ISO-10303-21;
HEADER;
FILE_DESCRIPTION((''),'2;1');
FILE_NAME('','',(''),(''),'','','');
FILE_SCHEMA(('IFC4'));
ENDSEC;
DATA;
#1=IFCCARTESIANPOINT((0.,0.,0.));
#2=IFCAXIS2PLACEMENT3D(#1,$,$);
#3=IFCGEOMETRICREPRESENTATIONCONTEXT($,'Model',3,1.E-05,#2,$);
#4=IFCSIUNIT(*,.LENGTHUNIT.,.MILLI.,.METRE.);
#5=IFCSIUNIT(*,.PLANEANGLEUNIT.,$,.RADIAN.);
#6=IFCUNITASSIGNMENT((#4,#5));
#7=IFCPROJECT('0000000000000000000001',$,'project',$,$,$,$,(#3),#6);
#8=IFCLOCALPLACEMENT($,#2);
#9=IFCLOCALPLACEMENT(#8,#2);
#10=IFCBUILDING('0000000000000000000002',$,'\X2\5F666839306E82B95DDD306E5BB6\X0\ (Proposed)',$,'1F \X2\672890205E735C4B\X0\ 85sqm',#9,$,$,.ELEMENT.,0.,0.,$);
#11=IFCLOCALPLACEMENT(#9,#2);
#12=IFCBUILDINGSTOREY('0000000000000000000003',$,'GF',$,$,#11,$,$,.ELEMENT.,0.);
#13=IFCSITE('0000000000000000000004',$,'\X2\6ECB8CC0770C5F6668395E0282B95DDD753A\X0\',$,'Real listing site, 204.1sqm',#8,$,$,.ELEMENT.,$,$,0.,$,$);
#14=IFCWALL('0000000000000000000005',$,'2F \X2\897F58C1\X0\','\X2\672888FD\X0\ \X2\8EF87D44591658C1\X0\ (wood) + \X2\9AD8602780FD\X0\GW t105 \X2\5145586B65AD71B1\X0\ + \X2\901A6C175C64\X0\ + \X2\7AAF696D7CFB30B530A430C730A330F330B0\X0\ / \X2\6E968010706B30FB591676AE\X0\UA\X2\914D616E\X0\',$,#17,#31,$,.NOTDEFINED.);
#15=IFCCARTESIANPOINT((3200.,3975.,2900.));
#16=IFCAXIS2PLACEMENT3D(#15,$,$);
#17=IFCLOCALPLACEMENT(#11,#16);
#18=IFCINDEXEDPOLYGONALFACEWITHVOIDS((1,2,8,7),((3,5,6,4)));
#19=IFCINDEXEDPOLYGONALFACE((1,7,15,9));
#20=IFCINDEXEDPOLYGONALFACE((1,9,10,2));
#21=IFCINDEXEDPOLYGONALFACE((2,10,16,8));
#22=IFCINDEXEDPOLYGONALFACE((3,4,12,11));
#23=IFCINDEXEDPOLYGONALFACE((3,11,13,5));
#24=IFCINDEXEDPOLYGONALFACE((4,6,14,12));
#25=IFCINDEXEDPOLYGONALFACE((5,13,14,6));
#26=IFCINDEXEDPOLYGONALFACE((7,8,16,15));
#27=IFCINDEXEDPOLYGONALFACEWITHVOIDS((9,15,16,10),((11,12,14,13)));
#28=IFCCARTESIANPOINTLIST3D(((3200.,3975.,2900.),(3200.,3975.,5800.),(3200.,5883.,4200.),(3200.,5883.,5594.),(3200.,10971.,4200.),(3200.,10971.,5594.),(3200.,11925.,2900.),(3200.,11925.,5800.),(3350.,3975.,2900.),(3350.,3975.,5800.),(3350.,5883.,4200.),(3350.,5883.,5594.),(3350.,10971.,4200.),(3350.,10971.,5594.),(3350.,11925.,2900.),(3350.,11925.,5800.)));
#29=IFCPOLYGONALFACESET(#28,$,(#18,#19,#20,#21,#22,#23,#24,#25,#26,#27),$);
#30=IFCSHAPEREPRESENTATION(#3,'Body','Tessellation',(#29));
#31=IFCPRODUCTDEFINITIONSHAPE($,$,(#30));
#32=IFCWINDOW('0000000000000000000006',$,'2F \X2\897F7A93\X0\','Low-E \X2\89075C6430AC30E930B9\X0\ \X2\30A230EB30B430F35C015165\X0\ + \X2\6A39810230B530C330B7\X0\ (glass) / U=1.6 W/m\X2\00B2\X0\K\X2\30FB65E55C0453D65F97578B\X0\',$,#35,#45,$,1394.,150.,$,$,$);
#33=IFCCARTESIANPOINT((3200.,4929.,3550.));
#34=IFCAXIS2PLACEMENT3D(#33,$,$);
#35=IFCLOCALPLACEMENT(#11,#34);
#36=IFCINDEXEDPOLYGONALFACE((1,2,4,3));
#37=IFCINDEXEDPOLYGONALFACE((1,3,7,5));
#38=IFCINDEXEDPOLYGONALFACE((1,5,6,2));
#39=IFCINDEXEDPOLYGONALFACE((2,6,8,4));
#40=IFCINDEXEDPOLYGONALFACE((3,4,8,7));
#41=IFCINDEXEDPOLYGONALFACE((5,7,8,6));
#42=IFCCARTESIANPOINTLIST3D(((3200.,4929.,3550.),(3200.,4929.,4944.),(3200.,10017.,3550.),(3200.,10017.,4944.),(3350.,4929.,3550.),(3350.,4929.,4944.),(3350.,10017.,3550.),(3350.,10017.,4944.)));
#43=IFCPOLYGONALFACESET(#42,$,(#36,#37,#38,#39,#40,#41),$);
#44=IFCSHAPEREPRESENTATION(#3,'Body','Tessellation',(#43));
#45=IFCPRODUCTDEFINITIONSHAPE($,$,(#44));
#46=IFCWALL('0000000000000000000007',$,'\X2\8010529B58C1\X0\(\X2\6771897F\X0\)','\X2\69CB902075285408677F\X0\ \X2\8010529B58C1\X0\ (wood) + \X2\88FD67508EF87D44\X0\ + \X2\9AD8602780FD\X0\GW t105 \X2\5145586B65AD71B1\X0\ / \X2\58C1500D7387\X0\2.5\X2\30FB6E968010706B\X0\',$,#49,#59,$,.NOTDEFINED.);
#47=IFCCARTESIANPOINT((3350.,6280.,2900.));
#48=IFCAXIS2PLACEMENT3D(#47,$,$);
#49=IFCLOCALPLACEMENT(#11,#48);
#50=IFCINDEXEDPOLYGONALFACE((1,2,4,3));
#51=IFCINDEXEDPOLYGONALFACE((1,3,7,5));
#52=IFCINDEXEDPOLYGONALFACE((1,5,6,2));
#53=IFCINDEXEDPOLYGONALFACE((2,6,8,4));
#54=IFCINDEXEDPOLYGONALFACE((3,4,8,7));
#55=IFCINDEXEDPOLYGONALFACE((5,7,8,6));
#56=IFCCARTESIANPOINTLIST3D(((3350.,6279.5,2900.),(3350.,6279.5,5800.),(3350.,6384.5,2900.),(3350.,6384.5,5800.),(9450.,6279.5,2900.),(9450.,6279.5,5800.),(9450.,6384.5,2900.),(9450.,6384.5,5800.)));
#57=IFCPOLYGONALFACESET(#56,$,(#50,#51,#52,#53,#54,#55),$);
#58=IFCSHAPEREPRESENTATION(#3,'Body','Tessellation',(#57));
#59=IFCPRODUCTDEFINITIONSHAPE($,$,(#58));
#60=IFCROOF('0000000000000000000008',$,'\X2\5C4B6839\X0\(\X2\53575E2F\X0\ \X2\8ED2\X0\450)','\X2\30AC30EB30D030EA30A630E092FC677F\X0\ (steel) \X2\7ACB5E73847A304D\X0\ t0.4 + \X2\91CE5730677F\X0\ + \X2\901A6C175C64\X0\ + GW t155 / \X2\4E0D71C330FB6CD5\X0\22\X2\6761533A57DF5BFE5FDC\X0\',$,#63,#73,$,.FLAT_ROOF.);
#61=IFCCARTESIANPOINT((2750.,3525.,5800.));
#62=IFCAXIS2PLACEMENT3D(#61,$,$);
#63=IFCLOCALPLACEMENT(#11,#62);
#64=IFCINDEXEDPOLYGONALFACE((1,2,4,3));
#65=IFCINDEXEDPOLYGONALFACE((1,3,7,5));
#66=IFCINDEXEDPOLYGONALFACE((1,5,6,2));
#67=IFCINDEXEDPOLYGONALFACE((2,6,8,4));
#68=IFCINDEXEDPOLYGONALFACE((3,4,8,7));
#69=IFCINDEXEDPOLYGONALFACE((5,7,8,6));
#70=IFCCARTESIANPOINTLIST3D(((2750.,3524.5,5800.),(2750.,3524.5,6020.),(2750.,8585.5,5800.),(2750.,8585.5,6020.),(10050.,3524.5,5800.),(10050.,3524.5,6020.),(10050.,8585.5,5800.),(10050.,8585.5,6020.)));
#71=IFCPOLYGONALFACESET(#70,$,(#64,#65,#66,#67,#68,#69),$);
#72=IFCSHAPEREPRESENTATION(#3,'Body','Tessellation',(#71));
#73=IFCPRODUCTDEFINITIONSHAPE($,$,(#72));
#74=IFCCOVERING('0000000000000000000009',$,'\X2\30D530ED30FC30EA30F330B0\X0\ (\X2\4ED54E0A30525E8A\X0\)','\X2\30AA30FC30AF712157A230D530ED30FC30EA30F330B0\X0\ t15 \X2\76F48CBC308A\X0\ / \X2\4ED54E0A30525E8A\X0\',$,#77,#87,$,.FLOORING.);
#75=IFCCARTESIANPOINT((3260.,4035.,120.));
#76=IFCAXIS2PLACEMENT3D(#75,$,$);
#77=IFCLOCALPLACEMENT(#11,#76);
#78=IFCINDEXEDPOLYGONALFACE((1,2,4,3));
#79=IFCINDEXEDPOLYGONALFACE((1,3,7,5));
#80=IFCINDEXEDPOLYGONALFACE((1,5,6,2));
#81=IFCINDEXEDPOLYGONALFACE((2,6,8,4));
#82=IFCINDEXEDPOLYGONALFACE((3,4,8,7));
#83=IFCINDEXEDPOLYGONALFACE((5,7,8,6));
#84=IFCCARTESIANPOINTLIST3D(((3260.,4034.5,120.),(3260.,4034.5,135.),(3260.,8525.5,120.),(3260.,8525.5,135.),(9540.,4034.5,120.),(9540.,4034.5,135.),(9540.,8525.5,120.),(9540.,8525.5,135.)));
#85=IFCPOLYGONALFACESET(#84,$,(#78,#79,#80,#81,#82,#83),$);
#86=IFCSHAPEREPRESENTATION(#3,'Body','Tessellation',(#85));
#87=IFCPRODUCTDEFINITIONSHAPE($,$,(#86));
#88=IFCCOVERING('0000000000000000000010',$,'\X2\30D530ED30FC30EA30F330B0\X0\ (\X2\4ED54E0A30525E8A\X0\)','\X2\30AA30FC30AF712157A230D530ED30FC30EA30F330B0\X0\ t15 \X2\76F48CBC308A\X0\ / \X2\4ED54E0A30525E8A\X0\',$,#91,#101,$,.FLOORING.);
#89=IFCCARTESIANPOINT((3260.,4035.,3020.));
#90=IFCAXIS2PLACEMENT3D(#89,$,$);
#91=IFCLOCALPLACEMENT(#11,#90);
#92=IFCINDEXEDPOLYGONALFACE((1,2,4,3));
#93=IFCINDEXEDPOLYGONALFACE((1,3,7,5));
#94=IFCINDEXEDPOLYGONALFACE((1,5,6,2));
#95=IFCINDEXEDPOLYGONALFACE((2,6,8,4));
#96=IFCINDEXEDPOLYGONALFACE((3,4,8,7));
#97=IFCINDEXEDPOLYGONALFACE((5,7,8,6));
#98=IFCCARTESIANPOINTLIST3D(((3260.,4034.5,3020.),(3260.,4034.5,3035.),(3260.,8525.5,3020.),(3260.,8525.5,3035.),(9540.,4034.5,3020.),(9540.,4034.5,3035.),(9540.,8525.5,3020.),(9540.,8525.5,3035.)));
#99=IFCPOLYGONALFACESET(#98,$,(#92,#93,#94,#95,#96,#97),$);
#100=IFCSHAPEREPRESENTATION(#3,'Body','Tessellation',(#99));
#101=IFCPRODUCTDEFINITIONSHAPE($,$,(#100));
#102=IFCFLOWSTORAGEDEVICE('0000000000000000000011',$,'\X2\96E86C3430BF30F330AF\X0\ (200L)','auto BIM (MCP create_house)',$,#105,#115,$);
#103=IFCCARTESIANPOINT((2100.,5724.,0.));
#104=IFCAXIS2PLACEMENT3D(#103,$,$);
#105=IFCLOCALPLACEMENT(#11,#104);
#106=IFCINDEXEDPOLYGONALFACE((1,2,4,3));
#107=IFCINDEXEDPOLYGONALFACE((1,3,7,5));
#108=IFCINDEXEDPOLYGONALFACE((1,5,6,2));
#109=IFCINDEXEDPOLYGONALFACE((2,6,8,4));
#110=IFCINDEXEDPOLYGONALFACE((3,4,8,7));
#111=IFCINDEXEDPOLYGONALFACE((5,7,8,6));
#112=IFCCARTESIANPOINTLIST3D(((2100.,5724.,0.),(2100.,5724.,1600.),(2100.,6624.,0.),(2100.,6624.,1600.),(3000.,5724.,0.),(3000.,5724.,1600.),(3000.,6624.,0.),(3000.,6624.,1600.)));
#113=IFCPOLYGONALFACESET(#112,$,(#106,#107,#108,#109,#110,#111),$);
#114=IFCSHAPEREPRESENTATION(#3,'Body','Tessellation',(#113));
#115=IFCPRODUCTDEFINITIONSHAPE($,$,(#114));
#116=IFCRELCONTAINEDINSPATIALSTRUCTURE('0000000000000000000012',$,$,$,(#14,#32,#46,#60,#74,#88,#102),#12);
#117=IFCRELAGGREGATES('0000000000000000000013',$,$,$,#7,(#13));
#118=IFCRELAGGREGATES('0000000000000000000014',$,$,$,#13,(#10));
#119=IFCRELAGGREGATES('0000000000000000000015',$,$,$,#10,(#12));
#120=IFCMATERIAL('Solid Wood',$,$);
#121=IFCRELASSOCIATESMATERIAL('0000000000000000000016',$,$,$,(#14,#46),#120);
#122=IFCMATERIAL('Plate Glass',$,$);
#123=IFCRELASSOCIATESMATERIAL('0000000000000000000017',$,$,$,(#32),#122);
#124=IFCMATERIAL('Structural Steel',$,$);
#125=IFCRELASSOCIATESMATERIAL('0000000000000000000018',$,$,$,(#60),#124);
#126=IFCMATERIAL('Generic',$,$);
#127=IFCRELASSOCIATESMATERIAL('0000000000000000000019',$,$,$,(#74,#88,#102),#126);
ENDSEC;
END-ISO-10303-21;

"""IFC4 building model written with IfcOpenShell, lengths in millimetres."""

from ifc_helpers import new_model, si_unit, frame, frame_2d, origin, place, context, project, spatial, rectangle, extrude, material, element, fill, save


model = new_model("IFC4")

# Units and contexts
model_context = context("Model", 3, precision=1e-05, world=origin())
ifc_project = project(units=[si_unit("LENGTHUNIT", "METRE", prefix="MILLI"), si_unit("PLANEANGLEUNIT", "RADIAN")], contexts=[model_context])

# Site, building, storey
site_placement = place(None, origin())
site = spatial("IfcSite", under=ifc_project, at=site_placement, Name="滋賀県彦根市芹川町", ObjectType="Real listing site, 204.1sqm", CompositionType="ELEMENT", RefElevation=0.0)
building_placement = place(site_placement, origin())
building = spatial("IfcBuilding", under=site, at=building_placement, Name="彦根の芹川の家 (Proposed)", ObjectType="1F 木造平屋 85sqm", CompositionType="ELEMENT", ElevationOfRefHeight=0.0, ElevationOfTerrain=0.0)
storey_placement = place(building_placement, origin())
storey = spatial("IfcBuildingStorey", under=building, at=storey_placement, Name="GF", CompositionType="ELEMENT", Elevation=0.0)

# Shared definitions
ifc_material_1 = material(Name="Solid Wood")
ifc_material_2 = material(Name="Generic")

# Shared definitions
ifc_material_3 = material(Name="Plate Glass")

# Wall, opening, window
wall_1_placement = place(storey_placement, frame((3200.0, 3975.0, 2900.0)))
wall_1 = element("IfcWall", 1, at=wall_1_placement, inside=storey, material=ifc_material_1, Name="2F 西壁", Description="木製 軸組外壁 (wood) + 高性能GW t105 充填断熱 + 通気層 + 窯業系サイディング / 準耐火・外皮UA配慮", PredefinedType="NOTDEFINED", context=model_context, shape_type="SweptSolid", body=[
    extrude(rectangle(XDim=150.0, YDim=7950.0, at=frame_2d((75.0, 3975.0))), frame((3200.0, 3975.0, 2900.0)), (0.0, 0.0, 1.0), 2900.0),
])
opening_1_placement = place(storey_placement, frame((3200.0, 4929.0, 3550.0)))
opening_1 = element("IfcOpeningElement", 2, at=opening_1_placement, cuts=wall_1, PredefinedType="NOTDEFINED", context=model_context, shape_type="SweptSolid", body=[
    extrude(rectangle(XDim=150.0, YDim=5088.0, at=frame_2d((75.0, 2544.0))), frame((3200.0, 4929.0, 3550.0)), (0.0, 0.0, 1.0), 1394.0),
])
window_1_placement = place(storey_placement, frame((3200.0, 4929.0, 3550.0)))
window_1 = element("IfcWindow", 3, at=window_1_placement, inside=storey, material=ifc_material_3, Name="2F 西窓", Description="Low-E 複層ガラス アルゴン封入 + 樹脂サッシ (glass) / U=1.6 W/m²K・日射取得型", OverallHeight=1394.0, OverallWidth=150.0, context=model_context, shape_type="SweptSolid", body=[
    extrude(rectangle(XDim=150.0, YDim=5088.0, at=frame_2d((75.0, 2544.0))), frame((3200.0, 4929.0, 3550.0)), (0.0, 0.0, 1.0), 1394.0),
])
fill(opening_1, window_1)

# Wall
wall_2_placement = place(storey_placement, frame((3350.0, 6280.0, 2900.0)))
element("IfcWall", 4, at=wall_2_placement, inside=storey, material=ifc_material_1, Name="耐力壁(東西)", Description="構造用合板 耐力壁 (wood) + 製材軸組 + 高性能GW t105 充填断熱 / 壁倍率2.5・準耐火", PredefinedType="NOTDEFINED", context=model_context, shape_type="SweptSolid", body=[
    extrude(rectangle(XDim=6100.0, YDim=105.0, at=frame_2d((3050.0, 52.0))), frame((3350.0, 6280.0, 2900.0)), (0.0, 0.0, 1.0), 2900.0),
])

# Roof
ifc_material_4 = material(Name="Structural Steel")
for number, where, name in (
    (5, (2750.0, 3525.0, 5800.0), "屋根(南帯 軒450)"),
):
    element("IfcRoof", number, at=place(storey_placement, frame(where)), inside=storey, material=ifc_material_4, Name=name, Description="ガルバリウム鋼板 (steel) 立平葺き t0.4 + 野地板 + 通気層 + GW t155 / 不燃・法22条区域対応", PredefinedType="FLAT_ROOF", context=model_context, shape_type="SweptSolid", body=[
        extrude(rectangle(XDim=7300.0, YDim=5061.0, at=frame_2d((3650.0, 2530.0))), frame((2750.0, 3525.0, 5800.0)), (0.0, 0.0, 1.0), 220.0),
    ])

# Coverings
covering_1_placement = place(storey_placement, frame((3260.0, 4035.0, 120.0)))
element("IfcCovering", 6, at=covering_1_placement, inside=storey, material=ifc_material_2, Name="フローリング (仕上げ床)", Description="オーク無垢フローリング t15 直貼り / 仕上げ床", PredefinedType="FLOORING", context=model_context, shape_type="SweptSolid", body=[
    extrude(rectangle(XDim=6280.0, YDim=4491.0, at=frame_2d((3140.0, 2245.0))), frame((3260.0, 4035.0, 120.0)), (0.0, 0.0, 1.0), 15.0),
])
covering_2_placement = place(storey_placement, frame((3260.0, 4035.0, 3020.0)))
element("IfcCovering", 7, at=covering_2_placement, inside=storey, material=ifc_material_2, Name="フローリング (仕上げ床)", Description="オーク無垢フローリング t15 直貼り / 仕上げ床", PredefinedType="FLOORING", context=model_context, shape_type="SweptSolid", body=[
    extrude(rectangle(XDim=6280.0, YDim=4491.0, at=frame_2d((3140.0, 2245.0))), frame((3260.0, 4035.0, 3020.0)), (0.0, 0.0, 1.0), 15.0),
])

# Flow storage device
flow_storage_device_placement = place(storey_placement, frame((2100.0, 5724.0, 0.0)))
element("IfcFlowStorageDevice", 8, at=flow_storage_device_placement, inside=storey, material=ifc_material_2, Name="雨水タンク (200L)", Description="auto BIM (MCP create_house)", context=model_context, shape_type="SweptSolid", body=[
    extrude(rectangle(XDim=900.0, YDim=900.0, at=frame_2d((450.0, 450.0))), frame((2100.0, 5724.0, 0.0)), (0.0, 0.0, 1.0), 1600.0),
])

save(model, "model.ifc")
